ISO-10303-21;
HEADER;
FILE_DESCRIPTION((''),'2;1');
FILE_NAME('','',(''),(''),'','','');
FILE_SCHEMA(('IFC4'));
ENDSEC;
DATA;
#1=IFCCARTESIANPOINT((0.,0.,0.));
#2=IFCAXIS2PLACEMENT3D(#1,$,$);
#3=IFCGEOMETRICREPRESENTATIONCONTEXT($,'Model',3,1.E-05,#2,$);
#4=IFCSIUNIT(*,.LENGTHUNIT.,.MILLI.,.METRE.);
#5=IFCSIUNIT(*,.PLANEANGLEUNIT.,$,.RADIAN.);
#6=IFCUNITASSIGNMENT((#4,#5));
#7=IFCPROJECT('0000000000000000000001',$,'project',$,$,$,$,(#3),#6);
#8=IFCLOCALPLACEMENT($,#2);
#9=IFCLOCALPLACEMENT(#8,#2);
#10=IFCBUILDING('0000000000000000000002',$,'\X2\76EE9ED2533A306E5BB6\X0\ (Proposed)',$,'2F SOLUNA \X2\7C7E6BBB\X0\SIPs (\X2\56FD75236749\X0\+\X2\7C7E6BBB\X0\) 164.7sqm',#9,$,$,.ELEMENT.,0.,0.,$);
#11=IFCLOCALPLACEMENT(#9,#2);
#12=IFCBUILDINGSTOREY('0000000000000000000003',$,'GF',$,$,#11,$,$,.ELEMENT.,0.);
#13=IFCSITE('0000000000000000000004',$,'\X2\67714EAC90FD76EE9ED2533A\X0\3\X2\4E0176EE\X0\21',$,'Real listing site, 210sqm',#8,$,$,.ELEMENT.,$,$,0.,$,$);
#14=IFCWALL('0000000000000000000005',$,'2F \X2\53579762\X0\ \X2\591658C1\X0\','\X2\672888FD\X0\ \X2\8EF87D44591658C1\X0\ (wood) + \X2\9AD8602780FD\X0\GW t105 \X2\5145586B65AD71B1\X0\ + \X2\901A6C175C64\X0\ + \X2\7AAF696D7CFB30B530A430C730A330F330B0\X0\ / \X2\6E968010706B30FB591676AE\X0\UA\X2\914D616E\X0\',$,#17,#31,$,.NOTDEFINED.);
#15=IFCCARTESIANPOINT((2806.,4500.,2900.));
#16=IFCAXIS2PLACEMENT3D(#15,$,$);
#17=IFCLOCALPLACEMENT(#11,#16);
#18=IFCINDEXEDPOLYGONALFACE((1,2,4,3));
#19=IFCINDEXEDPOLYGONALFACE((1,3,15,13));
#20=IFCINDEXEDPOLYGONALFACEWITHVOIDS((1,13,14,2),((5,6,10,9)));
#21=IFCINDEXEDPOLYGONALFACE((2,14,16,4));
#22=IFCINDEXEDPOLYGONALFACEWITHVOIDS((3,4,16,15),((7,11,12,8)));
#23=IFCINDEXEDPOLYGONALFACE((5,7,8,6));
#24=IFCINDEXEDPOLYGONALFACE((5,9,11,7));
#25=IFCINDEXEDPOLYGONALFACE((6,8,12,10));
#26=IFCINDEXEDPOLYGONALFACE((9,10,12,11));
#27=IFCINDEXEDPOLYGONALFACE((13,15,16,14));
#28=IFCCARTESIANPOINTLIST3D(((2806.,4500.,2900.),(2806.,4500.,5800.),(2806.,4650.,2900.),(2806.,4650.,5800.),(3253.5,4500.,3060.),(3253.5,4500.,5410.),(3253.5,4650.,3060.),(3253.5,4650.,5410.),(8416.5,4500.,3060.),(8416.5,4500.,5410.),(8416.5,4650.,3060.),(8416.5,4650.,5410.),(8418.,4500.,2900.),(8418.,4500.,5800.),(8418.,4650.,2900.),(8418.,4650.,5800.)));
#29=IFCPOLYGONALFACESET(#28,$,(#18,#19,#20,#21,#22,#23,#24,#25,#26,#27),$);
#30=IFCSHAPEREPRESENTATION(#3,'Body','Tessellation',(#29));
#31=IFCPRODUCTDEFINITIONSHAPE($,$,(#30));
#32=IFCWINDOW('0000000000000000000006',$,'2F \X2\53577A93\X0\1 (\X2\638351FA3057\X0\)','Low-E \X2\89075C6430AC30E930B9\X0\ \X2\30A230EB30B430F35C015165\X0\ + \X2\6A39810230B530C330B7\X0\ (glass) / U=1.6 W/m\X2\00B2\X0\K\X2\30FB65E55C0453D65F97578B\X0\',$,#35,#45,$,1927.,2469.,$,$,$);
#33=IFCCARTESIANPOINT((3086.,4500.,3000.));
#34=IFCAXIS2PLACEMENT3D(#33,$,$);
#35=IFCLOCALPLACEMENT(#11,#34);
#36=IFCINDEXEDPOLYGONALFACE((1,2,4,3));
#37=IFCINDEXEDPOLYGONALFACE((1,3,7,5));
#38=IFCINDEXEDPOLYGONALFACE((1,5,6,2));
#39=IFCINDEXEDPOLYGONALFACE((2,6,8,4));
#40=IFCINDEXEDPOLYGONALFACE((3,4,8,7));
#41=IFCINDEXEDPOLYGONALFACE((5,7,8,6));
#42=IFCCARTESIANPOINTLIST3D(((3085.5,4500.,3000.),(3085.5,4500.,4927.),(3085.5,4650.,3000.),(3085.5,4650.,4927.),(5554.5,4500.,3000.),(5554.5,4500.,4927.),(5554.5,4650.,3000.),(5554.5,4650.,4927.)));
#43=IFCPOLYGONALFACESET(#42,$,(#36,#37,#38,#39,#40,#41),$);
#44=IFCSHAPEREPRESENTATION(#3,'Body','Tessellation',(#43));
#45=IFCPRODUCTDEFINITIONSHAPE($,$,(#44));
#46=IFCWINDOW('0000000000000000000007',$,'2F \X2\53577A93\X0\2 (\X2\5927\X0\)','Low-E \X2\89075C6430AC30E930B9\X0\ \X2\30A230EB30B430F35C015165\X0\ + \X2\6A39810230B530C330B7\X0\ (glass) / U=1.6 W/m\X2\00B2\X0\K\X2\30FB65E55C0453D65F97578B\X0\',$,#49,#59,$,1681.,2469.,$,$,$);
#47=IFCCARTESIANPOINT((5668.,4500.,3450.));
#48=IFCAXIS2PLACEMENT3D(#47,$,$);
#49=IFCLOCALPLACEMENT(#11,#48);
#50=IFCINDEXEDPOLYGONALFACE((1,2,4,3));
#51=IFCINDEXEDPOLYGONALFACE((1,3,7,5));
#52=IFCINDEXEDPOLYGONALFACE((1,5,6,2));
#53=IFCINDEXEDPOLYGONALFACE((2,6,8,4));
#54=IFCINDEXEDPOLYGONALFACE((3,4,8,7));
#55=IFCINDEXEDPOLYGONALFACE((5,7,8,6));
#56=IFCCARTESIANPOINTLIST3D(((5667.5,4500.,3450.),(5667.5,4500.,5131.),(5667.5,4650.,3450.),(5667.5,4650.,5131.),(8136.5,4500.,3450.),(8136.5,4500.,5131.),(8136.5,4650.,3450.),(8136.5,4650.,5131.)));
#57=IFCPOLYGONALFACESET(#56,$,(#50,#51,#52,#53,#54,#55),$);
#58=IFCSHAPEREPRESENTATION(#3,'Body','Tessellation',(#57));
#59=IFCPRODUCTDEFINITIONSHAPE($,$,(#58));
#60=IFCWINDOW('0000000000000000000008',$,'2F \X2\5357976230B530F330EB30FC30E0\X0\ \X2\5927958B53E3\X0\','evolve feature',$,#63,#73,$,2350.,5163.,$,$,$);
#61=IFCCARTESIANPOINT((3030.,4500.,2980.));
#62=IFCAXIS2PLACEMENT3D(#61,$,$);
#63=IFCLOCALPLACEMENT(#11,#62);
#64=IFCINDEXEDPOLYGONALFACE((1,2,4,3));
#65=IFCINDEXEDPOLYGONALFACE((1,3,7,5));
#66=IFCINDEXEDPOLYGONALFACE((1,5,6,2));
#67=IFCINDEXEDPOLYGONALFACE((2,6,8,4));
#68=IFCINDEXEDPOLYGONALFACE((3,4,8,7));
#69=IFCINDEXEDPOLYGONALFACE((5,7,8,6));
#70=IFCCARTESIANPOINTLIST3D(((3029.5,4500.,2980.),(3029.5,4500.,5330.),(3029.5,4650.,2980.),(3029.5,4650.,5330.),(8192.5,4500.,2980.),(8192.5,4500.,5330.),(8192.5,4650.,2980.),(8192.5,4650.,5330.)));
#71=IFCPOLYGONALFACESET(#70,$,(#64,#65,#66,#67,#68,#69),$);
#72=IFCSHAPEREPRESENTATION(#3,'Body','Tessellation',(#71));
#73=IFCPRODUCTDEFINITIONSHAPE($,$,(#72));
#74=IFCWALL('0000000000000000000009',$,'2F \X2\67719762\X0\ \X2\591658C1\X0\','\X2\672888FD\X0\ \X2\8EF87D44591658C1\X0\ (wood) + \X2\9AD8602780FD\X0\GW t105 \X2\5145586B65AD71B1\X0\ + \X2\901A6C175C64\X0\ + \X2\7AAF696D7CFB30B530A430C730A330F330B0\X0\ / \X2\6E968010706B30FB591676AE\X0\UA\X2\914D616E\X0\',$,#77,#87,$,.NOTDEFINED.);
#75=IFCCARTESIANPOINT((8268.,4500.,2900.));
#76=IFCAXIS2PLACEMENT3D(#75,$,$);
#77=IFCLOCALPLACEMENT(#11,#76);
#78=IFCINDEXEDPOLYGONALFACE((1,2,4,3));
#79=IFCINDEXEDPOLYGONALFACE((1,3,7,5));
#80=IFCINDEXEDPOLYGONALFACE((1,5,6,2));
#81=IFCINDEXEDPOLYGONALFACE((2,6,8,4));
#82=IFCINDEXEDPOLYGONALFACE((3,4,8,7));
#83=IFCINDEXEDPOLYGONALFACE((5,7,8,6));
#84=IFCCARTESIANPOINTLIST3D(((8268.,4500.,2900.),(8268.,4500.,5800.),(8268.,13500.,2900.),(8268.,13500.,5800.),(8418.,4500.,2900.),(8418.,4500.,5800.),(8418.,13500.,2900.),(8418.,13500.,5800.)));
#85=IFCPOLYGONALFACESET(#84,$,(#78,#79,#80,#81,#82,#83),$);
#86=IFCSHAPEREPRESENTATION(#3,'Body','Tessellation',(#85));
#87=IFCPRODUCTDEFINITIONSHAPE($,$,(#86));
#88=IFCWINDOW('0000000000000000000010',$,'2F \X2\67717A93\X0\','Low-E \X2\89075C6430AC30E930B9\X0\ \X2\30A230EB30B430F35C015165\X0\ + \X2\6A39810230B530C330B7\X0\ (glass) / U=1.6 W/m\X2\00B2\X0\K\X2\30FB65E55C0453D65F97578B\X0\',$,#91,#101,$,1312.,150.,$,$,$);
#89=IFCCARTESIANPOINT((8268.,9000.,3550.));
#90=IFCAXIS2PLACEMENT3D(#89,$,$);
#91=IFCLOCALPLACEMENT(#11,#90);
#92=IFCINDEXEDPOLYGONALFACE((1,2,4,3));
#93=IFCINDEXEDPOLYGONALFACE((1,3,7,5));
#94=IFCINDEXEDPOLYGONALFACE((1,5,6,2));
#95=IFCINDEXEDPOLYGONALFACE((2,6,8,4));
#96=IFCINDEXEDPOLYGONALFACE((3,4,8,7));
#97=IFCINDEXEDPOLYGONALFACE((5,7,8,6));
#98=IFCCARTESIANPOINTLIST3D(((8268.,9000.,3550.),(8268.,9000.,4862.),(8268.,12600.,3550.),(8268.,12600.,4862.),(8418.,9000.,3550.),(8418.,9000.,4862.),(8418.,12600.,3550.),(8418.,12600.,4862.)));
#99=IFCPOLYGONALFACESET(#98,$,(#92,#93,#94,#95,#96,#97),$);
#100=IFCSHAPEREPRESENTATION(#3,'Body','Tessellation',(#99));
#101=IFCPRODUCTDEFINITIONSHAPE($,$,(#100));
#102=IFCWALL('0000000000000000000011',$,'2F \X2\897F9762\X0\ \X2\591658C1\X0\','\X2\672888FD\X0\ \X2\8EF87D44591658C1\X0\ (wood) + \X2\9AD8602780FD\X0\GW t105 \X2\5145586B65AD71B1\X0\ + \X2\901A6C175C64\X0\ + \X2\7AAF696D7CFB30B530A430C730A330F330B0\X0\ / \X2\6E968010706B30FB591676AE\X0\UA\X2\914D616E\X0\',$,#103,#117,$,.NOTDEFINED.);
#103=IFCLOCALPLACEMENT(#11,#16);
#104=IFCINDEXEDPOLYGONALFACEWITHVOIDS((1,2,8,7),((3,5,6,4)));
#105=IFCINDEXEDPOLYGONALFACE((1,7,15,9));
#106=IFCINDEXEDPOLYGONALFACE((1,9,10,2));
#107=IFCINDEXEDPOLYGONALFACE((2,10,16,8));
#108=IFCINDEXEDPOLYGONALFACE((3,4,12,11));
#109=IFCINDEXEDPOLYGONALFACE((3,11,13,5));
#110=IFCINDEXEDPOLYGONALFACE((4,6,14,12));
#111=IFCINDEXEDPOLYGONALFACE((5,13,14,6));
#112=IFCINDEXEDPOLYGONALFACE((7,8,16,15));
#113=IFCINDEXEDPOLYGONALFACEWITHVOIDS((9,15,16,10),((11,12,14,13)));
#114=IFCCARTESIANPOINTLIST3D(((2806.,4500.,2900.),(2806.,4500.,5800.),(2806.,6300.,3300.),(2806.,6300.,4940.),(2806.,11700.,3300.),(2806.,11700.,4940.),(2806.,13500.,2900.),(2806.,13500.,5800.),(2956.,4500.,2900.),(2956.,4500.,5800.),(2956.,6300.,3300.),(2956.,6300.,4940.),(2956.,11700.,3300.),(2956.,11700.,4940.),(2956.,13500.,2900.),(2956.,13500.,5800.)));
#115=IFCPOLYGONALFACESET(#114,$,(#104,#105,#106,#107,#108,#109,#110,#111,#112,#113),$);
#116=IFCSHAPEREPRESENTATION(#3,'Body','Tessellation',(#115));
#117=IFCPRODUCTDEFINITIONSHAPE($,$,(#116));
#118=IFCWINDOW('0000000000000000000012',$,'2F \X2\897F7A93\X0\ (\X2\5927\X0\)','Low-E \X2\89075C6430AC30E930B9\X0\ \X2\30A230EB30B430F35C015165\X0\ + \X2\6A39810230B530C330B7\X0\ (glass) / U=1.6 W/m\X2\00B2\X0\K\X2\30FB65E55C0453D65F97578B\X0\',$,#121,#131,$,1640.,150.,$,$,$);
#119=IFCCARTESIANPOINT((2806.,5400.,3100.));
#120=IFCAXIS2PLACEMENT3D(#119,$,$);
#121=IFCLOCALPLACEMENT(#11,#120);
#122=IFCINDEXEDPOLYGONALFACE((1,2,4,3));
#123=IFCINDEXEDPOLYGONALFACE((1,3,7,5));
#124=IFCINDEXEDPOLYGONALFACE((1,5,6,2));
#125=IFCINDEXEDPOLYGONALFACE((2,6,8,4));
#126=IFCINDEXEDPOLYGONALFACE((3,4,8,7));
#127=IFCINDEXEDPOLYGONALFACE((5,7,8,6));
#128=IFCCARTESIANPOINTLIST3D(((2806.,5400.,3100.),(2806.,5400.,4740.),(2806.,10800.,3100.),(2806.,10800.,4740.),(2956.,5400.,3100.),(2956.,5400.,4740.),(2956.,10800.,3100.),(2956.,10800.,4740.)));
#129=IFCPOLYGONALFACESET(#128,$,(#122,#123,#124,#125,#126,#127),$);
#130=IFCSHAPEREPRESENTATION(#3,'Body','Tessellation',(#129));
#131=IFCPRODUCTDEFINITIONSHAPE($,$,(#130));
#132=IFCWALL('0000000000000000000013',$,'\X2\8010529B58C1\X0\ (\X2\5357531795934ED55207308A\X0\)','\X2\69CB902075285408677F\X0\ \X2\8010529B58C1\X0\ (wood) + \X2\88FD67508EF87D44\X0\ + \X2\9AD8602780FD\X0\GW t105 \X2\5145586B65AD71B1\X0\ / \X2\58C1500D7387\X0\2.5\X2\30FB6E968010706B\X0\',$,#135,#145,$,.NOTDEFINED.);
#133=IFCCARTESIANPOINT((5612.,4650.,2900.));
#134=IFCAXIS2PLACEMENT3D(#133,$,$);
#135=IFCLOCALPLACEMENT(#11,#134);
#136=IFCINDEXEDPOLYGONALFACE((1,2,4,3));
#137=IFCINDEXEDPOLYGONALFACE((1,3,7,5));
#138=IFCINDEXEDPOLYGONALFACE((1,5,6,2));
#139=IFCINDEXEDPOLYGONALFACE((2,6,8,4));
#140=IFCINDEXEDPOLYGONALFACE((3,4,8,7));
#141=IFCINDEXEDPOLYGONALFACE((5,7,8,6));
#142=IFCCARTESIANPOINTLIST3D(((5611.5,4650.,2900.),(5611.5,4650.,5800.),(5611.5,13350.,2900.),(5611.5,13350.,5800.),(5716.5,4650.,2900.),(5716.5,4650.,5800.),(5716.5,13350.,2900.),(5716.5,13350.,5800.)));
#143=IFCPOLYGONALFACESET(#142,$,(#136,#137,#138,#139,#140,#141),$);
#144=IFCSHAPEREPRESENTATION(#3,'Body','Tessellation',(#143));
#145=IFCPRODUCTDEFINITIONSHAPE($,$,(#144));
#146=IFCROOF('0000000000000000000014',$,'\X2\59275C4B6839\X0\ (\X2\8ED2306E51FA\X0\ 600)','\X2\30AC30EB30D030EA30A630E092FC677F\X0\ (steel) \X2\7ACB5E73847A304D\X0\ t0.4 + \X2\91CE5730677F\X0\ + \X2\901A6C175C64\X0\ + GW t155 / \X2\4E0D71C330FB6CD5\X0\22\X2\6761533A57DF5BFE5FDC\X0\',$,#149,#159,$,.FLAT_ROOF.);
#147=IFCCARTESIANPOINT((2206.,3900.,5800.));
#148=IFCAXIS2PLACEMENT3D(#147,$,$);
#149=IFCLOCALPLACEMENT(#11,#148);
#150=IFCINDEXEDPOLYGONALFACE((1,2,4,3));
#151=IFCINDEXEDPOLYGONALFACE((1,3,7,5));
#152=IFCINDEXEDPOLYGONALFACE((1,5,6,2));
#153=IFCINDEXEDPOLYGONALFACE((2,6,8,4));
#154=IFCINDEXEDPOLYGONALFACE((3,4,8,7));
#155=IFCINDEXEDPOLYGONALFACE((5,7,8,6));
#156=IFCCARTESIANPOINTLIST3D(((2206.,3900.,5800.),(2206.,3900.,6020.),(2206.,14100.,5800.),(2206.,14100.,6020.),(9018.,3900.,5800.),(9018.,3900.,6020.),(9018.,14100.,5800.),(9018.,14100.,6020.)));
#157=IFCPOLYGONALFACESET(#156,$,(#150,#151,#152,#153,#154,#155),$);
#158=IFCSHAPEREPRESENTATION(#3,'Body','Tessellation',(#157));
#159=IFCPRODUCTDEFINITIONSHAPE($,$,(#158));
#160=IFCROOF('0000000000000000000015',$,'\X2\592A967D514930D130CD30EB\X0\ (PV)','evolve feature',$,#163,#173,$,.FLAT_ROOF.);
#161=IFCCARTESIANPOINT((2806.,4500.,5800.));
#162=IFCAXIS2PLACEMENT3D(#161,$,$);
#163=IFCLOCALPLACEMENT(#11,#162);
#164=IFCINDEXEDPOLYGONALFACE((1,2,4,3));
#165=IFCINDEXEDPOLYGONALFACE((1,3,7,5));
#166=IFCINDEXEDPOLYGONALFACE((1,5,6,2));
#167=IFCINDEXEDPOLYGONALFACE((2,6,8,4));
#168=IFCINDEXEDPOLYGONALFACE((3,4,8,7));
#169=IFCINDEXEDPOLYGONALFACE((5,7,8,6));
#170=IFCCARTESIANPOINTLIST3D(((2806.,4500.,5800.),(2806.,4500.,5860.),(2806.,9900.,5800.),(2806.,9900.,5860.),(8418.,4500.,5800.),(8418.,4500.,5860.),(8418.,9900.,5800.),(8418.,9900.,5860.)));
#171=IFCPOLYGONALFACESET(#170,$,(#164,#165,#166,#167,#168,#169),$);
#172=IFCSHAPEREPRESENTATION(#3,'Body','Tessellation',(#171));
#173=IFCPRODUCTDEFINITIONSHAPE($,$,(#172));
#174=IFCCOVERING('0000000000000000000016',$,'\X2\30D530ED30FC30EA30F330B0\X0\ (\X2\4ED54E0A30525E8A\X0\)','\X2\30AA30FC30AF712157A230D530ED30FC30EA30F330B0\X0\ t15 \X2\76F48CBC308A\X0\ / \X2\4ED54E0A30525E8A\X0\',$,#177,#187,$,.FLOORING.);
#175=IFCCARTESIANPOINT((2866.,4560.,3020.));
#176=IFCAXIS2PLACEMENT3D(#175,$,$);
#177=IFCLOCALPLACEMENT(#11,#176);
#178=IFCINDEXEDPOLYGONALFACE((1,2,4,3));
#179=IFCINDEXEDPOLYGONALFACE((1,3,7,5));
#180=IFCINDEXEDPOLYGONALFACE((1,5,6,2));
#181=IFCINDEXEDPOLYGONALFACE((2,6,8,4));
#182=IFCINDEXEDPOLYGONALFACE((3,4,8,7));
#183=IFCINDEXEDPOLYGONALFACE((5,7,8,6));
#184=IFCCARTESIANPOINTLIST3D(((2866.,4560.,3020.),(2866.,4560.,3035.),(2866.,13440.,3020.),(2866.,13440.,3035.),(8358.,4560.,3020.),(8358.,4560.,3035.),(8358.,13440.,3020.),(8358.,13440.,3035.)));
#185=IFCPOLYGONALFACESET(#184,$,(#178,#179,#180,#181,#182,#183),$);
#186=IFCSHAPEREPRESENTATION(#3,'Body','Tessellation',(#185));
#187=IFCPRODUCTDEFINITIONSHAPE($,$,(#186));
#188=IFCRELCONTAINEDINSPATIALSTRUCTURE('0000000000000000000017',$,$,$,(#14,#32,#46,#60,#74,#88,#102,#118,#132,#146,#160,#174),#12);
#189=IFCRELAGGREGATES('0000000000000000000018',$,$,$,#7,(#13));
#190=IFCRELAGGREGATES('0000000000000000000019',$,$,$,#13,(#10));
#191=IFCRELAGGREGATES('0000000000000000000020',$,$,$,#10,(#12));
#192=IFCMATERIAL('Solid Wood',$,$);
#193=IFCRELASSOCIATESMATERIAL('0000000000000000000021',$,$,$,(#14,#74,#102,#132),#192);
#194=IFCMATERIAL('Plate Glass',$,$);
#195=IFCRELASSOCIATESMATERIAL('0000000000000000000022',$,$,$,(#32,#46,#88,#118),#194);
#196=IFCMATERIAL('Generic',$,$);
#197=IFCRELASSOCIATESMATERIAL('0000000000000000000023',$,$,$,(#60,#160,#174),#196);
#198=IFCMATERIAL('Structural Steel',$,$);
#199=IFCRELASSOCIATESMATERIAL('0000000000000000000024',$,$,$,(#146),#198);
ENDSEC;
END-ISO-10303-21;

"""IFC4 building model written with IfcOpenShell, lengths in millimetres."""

from ifc_helpers import new_model, si_unit, frame, frame_2d, origin, place, context, project, spatial, rectangle, extrude, material, element, fill, save


model = new_model("IFC4")

# Units and contexts
model_context = context("Model", 3, precision=1e-05, world=origin())
ifc_project = project(units=[si_unit("LENGTHUNIT", "METRE", prefix="MILLI"), si_unit("PLANEANGLEUNIT", "RADIAN")], contexts=[model_context])

# Site, building, storey
site_placement = place(None, origin())
site = spatial("IfcSite", under=ifc_project, at=site_placement, Name="東京都目黒区3丁目21", ObjectType="Real listing site, 210sqm", CompositionType="ELEMENT", RefElevation=0.0)
building_placement = place(site_placement, origin())
building = spatial("IfcBuilding", under=site, at=building_placement, Name="目黒区の家 (Proposed)", ObjectType="2F SOLUNA 籾殻SIPs (国産杉+籾殻) 164.7sqm", CompositionType="ELEMENT", ElevationOfRefHeight=0.0, ElevationOfTerrain=0.0)
storey_placement = place(building_placement, origin())
storey = spatial("IfcBuildingStorey", under=building, at=storey_placement, Name="GF", CompositionType="ELEMENT", Elevation=0.0)

# Shared definitions
ifc_material_1 = material(Name="Solid Wood")

# Wall, openings, windows
wall_1_placement = place(storey_placement, frame((2806.0, 4500.0, 2900.0)))
wall_1 = element("IfcWall", 1, at=wall_1_placement, inside=storey, material=ifc_material_1, Name="2F 南面 外壁", Description="木製 軸組外壁 (wood) + 高性能GW t105 充填断熱 + 通気層 + 窯業系サイディング / 準耐火・外皮UA配慮", PredefinedType="NOTDEFINED", context=model_context, shape_type="SweptSolid", body=[
    extrude(rectangle(XDim=5612.0, YDim=150.0, at=frame_2d((2806.0, 75.0))), frame((2806.0, 4500.0, 2900.0)), (0.0, 0.0, 1.0), 2900.0),
])
opening_1_placement = place(storey_placement, frame((3086.0, 4500.0, 3000.0)))
opening_1 = element("IfcOpeningElement", 2, at=opening_1_placement, cuts=wall_1, PredefinedType="NOTDEFINED", context=model_context, shape_type="SweptSolid", body=[
    extrude(rectangle(XDim=2469.0, YDim=150.0, at=frame_2d((1234.0, 75.0))), frame((3086.0, 4500.0, 3000.0)), (0.0, 0.0, 1.0), 1927.0),
])
opening_2_placement = place(storey_placement, frame((5668.0, 4500.0, 3450.0)))
opening_2 = element("IfcOpeningElement", 3, at=opening_2_placement, cuts=wall_1, PredefinedType="NOTDEFINED", context=model_context, shape_type="SweptSolid", body=[
    extrude(rectangle(XDim=2469.0, YDim=150.0, at=frame_2d((1234.0, 75.0))), frame((5668.0, 4500.0, 3450.0)), (0.0, 0.0, 1.0), 1681.0),
])
opening_3_placement = place(storey_placement, frame((3030.0, 4500.0, 2980.0)))
opening_3 = element("IfcOpeningElement", 4, at=opening_3_placement, cuts=wall_1, PredefinedType="NOTDEFINED", context=model_context, shape_type="SweptSolid", body=[
    extrude(rectangle(XDim=5163.0, YDim=150.0, at=frame_2d((2581.0, 75.0))), frame((3030.0, 4500.0, 2980.0)), (0.0, 0.0, 1.0), 2350.0),
])
ifc_material_2 = material(Name="Plate Glass")
window_1_placement = place(storey_placement, frame((3086.0, 4500.0, 3000.0)))
window_1 = element("IfcWindow", 5, at=window_1_placement, inside=storey, material=ifc_material_2, Name="2F 南窓1 (掃出し)", Description="Low-E 複層ガラス アルゴン封入 + 樹脂サッシ (glass) / U=1.6 W/m²K・日射取得型", OverallHeight=1927.0, OverallWidth=2469.0, context=model_context, shape_type="SweptSolid", body=[
    extrude(rectangle(XDim=2469.0, YDim=150.0, at=frame_2d((1234.0, 75.0))), frame((3086.0, 4500.0, 3000.0)), (0.0, 0.0, 1.0), 1927.0),
])
fill(opening_1, window_1)
window_2_placement = place(storey_placement, frame((5668.0, 4500.0, 3450.0)))
window_2 = element("IfcWindow", 6, at=window_2_placement, inside=storey, material=ifc_material_2, Name="2F 南窓2 (大)", Description="Low-E 複層ガラス アルゴン封入 + 樹脂サッシ (glass) / U=1.6 W/m²K・日射取得型", OverallHeight=1681.0, OverallWidth=2469.0, context=model_context, shape_type="SweptSolid", body=[
    extrude(rectangle(XDim=2469.0, YDim=150.0, at=frame_2d((1234.0, 75.0))), frame((5668.0, 4500.0, 3450.0)), (0.0, 0.0, 1.0), 1681.0),
])
fill(opening_2, window_2)
ifc_material_3 = material(Name="Generic")
window_3_placement = place(storey_placement, frame((3030.0, 4500.0, 2980.0)))
window_3 = element("IfcWindow", 7, at=window_3_placement, inside=storey, material=ifc_material_3, Name="2F 南面サンルーム 大開口", Description="evolve feature", OverallHeight=2350.0, OverallWidth=5163.0, context=model_context, shape_type="SweptSolid", body=[
    extrude(rectangle(XDim=5163.0, YDim=150.0, at=frame_2d((2581.0, 75.0))), frame((3030.0, 4500.0, 2980.0)), (0.0, 0.0, 1.0), 2350.0),
])
fill(opening_3, window_3)

# Walls, openings, windows
wall_2_placement = place(storey_placement, frame((8268.0, 4500.0, 2900.0)))
wall_2 = element("IfcWall", 8, at=wall_2_placement, inside=storey, material=ifc_material_1, Name="2F 東面 外壁", Description="木製 軸組外壁 (wood) + 高性能GW t105 充填断熱 + 通気層 + 窯業系サイディング / 準耐火・外皮UA配慮", PredefinedType="NOTDEFINED", context=model_context, shape_type="SweptSolid", body=[
    extrude(rectangle(XDim=150.0, YDim=9000.0, at=frame_2d((75.0, 4500.0))), frame((8268.0, 4500.0, 2900.0)), (0.0, 0.0, 1.0), 2900.0),
])
opening_4_placement = place(storey_placement, frame((8268.0, 9000.0, 3550.0)))
opening_4 = element("IfcOpeningElement", 9, at=opening_4_placement, cuts=wall_2, PredefinedType="NOTDEFINED", context=model_context, shape_type="SweptSolid", body=[
    extrude(rectangle(XDim=150.0, YDim=3600.0, at=frame_2d((75.0, 1800.0))), frame((8268.0, 9000.0, 3550.0)), (0.0, 0.0, 1.0), 1312.0),
])
window_4_placement = place(storey_placement, frame((8268.0, 9000.0, 3550.0)))
window_4 = element("IfcWindow", 10, at=window_4_placement, inside=storey, material=ifc_material_2, Name="2F 東窓", Description="Low-E 複層ガラス アルゴン封入 + 樹脂サッシ (glass) / U=1.6 W/m²K・日射取得型", OverallHeight=1312.0, OverallWidth=150.0, context=model_context, shape_type="SweptSolid", body=[
    extrude(rectangle(XDim=150.0, YDim=3600.0, at=frame_2d((75.0, 1800.0))), frame((8268.0, 9000.0, 3550.0)), (0.0, 0.0, 1.0), 1312.0),
])
fill(opening_4, window_4)
wall_3_placement = place(storey_placement, frame((2806.0, 4500.0, 2900.0)))
wall_3 = element("IfcWall", 11, at=wall_3_placement, inside=storey, material=ifc_material_1, Name="2F 西面 外壁", Description="木製 軸組外壁 (wood) + 高性能GW t105 充填断熱 + 通気層 + 窯業系サイディング / 準耐火・外皮UA配慮", PredefinedType="NOTDEFINED", context=model_context, shape_type="SweptSolid", body=[
    extrude(rectangle(XDim=150.0, YDim=9000.0, at=frame_2d((75.0, 4500.0))), frame((2806.0, 4500.0, 2900.0)), (0.0, 0.0, 1.0), 2900.0),
])
opening_5_placement = place(storey_placement, frame((2806.0, 5400.0, 3100.0)))
opening_5 = element("IfcOpeningElement", 12, at=opening_5_placement, cuts=wall_3, PredefinedType="NOTDEFINED", context=model_context, shape_type="SweptSolid", body=[
    extrude(rectangle(XDim=150.0, YDim=5400.0, at=frame_2d((75.0, 2700.0))), frame((2806.0, 5400.0, 3100.0)), (0.0, 0.0, 1.0), 1640.0),
])
window_5_placement = place(storey_placement, frame((2806.0, 5400.0, 3100.0)))
window_5 = element("IfcWindow", 13, at=window_5_placement, inside=storey, material=ifc_material_2, Name="2F 西窓 (大)", Description="Low-E 複層ガラス アルゴン封入 + 樹脂サッシ (glass) / U=1.6 W/m²K・日射取得型", OverallHeight=1640.0, OverallWidth=150.0, context=model_context, shape_type="SweptSolid", body=[
    extrude(rectangle(XDim=150.0, YDim=5400.0, at=frame_2d((75.0, 2700.0))), frame((2806.0, 5400.0, 3100.0)), (0.0, 0.0, 1.0), 1640.0),
])
fill(opening_5, window_5)

# Wall
wall_4_placement = place(storey_placement, frame((5612.0, 4650.0, 2900.0)))
element("IfcWall", 14, at=wall_4_placement, inside=storey, material=ifc_material_1, Name="耐力壁 (南北間仕切り)", Description="構造用合板 耐力壁 (wood) + 製材軸組 + 高性能GW t105 充填断熱 / 壁倍率2.5・準耐火", PredefinedType="NOTDEFINED", context=model_context, shape_type="SweptSolid", body=[
    extrude(rectangle(XDim=105.0, YDim=8700.0, at=frame_2d((52.0, 4350.0))), frame((5612.0, 4650.0, 2900.0)), (0.0, 0.0, 1.0), 2900.0),
])

# Roofs
ifc_material_4 = material(Name="Structural Steel")
roof_1_placement = place(storey_placement, frame((2206.0, 3900.0, 5800.0)))
element("IfcRoof", 15, at=roof_1_placement, inside=storey, material=ifc_material_4, Name="大屋根 (軒の出 600)", Description="ガルバリウム鋼板 (steel) 立平葺き t0.4 + 野地板 + 通気層 + GW t155 / 不燃・法22条区域対応", PredefinedType="FLAT_ROOF", context=model_context, shape_type="SweptSolid", body=[
    extrude(rectangle(XDim=6812.0, YDim=10200.0, at=frame_2d((3406.0, 5100.0))), frame((2206.0, 3900.0, 5800.0)), (0.0, 0.0, 1.0), 220.0),
])
roof_2_placement = place(storey_placement, frame((2806.0, 4500.0, 5800.0)))
element("IfcRoof", 16, at=roof_2_placement, inside=storey, material=ifc_material_3, Name="太陽光パネル (PV)", Description="evolve feature", PredefinedType="FLAT_ROOF", context=model_context, shape_type="SweptSolid", body=[
    extrude(rectangle(XDim=5612.0, YDim=5400.0, at=frame_2d((2806.0, 2700.0))), frame((2806.0, 4500.0, 5800.0)), (0.0, 0.0, 1.0), 60.0),
])

# Covering
covering_placement = place(storey_placement, frame((2866.0, 4560.0, 3020.0)))
element("IfcCovering", 17, at=covering_placement, inside=storey, material=ifc_material_3, Name="フローリング (仕上げ床)", Description="オーク無垢フローリング t15 直貼り / 仕上げ床", PredefinedType="FLOORING", context=model_context, shape_type="SweptSolid", body=[
    extrude(rectangle(XDim=5492.0, YDim=8880.0, at=frame_2d((2746.0, 4440.0))), frame((2866.0, 4560.0, 3020.0)), (0.0, 0.0, 1.0), 15.0),
])

save(model, "model.ifc")
